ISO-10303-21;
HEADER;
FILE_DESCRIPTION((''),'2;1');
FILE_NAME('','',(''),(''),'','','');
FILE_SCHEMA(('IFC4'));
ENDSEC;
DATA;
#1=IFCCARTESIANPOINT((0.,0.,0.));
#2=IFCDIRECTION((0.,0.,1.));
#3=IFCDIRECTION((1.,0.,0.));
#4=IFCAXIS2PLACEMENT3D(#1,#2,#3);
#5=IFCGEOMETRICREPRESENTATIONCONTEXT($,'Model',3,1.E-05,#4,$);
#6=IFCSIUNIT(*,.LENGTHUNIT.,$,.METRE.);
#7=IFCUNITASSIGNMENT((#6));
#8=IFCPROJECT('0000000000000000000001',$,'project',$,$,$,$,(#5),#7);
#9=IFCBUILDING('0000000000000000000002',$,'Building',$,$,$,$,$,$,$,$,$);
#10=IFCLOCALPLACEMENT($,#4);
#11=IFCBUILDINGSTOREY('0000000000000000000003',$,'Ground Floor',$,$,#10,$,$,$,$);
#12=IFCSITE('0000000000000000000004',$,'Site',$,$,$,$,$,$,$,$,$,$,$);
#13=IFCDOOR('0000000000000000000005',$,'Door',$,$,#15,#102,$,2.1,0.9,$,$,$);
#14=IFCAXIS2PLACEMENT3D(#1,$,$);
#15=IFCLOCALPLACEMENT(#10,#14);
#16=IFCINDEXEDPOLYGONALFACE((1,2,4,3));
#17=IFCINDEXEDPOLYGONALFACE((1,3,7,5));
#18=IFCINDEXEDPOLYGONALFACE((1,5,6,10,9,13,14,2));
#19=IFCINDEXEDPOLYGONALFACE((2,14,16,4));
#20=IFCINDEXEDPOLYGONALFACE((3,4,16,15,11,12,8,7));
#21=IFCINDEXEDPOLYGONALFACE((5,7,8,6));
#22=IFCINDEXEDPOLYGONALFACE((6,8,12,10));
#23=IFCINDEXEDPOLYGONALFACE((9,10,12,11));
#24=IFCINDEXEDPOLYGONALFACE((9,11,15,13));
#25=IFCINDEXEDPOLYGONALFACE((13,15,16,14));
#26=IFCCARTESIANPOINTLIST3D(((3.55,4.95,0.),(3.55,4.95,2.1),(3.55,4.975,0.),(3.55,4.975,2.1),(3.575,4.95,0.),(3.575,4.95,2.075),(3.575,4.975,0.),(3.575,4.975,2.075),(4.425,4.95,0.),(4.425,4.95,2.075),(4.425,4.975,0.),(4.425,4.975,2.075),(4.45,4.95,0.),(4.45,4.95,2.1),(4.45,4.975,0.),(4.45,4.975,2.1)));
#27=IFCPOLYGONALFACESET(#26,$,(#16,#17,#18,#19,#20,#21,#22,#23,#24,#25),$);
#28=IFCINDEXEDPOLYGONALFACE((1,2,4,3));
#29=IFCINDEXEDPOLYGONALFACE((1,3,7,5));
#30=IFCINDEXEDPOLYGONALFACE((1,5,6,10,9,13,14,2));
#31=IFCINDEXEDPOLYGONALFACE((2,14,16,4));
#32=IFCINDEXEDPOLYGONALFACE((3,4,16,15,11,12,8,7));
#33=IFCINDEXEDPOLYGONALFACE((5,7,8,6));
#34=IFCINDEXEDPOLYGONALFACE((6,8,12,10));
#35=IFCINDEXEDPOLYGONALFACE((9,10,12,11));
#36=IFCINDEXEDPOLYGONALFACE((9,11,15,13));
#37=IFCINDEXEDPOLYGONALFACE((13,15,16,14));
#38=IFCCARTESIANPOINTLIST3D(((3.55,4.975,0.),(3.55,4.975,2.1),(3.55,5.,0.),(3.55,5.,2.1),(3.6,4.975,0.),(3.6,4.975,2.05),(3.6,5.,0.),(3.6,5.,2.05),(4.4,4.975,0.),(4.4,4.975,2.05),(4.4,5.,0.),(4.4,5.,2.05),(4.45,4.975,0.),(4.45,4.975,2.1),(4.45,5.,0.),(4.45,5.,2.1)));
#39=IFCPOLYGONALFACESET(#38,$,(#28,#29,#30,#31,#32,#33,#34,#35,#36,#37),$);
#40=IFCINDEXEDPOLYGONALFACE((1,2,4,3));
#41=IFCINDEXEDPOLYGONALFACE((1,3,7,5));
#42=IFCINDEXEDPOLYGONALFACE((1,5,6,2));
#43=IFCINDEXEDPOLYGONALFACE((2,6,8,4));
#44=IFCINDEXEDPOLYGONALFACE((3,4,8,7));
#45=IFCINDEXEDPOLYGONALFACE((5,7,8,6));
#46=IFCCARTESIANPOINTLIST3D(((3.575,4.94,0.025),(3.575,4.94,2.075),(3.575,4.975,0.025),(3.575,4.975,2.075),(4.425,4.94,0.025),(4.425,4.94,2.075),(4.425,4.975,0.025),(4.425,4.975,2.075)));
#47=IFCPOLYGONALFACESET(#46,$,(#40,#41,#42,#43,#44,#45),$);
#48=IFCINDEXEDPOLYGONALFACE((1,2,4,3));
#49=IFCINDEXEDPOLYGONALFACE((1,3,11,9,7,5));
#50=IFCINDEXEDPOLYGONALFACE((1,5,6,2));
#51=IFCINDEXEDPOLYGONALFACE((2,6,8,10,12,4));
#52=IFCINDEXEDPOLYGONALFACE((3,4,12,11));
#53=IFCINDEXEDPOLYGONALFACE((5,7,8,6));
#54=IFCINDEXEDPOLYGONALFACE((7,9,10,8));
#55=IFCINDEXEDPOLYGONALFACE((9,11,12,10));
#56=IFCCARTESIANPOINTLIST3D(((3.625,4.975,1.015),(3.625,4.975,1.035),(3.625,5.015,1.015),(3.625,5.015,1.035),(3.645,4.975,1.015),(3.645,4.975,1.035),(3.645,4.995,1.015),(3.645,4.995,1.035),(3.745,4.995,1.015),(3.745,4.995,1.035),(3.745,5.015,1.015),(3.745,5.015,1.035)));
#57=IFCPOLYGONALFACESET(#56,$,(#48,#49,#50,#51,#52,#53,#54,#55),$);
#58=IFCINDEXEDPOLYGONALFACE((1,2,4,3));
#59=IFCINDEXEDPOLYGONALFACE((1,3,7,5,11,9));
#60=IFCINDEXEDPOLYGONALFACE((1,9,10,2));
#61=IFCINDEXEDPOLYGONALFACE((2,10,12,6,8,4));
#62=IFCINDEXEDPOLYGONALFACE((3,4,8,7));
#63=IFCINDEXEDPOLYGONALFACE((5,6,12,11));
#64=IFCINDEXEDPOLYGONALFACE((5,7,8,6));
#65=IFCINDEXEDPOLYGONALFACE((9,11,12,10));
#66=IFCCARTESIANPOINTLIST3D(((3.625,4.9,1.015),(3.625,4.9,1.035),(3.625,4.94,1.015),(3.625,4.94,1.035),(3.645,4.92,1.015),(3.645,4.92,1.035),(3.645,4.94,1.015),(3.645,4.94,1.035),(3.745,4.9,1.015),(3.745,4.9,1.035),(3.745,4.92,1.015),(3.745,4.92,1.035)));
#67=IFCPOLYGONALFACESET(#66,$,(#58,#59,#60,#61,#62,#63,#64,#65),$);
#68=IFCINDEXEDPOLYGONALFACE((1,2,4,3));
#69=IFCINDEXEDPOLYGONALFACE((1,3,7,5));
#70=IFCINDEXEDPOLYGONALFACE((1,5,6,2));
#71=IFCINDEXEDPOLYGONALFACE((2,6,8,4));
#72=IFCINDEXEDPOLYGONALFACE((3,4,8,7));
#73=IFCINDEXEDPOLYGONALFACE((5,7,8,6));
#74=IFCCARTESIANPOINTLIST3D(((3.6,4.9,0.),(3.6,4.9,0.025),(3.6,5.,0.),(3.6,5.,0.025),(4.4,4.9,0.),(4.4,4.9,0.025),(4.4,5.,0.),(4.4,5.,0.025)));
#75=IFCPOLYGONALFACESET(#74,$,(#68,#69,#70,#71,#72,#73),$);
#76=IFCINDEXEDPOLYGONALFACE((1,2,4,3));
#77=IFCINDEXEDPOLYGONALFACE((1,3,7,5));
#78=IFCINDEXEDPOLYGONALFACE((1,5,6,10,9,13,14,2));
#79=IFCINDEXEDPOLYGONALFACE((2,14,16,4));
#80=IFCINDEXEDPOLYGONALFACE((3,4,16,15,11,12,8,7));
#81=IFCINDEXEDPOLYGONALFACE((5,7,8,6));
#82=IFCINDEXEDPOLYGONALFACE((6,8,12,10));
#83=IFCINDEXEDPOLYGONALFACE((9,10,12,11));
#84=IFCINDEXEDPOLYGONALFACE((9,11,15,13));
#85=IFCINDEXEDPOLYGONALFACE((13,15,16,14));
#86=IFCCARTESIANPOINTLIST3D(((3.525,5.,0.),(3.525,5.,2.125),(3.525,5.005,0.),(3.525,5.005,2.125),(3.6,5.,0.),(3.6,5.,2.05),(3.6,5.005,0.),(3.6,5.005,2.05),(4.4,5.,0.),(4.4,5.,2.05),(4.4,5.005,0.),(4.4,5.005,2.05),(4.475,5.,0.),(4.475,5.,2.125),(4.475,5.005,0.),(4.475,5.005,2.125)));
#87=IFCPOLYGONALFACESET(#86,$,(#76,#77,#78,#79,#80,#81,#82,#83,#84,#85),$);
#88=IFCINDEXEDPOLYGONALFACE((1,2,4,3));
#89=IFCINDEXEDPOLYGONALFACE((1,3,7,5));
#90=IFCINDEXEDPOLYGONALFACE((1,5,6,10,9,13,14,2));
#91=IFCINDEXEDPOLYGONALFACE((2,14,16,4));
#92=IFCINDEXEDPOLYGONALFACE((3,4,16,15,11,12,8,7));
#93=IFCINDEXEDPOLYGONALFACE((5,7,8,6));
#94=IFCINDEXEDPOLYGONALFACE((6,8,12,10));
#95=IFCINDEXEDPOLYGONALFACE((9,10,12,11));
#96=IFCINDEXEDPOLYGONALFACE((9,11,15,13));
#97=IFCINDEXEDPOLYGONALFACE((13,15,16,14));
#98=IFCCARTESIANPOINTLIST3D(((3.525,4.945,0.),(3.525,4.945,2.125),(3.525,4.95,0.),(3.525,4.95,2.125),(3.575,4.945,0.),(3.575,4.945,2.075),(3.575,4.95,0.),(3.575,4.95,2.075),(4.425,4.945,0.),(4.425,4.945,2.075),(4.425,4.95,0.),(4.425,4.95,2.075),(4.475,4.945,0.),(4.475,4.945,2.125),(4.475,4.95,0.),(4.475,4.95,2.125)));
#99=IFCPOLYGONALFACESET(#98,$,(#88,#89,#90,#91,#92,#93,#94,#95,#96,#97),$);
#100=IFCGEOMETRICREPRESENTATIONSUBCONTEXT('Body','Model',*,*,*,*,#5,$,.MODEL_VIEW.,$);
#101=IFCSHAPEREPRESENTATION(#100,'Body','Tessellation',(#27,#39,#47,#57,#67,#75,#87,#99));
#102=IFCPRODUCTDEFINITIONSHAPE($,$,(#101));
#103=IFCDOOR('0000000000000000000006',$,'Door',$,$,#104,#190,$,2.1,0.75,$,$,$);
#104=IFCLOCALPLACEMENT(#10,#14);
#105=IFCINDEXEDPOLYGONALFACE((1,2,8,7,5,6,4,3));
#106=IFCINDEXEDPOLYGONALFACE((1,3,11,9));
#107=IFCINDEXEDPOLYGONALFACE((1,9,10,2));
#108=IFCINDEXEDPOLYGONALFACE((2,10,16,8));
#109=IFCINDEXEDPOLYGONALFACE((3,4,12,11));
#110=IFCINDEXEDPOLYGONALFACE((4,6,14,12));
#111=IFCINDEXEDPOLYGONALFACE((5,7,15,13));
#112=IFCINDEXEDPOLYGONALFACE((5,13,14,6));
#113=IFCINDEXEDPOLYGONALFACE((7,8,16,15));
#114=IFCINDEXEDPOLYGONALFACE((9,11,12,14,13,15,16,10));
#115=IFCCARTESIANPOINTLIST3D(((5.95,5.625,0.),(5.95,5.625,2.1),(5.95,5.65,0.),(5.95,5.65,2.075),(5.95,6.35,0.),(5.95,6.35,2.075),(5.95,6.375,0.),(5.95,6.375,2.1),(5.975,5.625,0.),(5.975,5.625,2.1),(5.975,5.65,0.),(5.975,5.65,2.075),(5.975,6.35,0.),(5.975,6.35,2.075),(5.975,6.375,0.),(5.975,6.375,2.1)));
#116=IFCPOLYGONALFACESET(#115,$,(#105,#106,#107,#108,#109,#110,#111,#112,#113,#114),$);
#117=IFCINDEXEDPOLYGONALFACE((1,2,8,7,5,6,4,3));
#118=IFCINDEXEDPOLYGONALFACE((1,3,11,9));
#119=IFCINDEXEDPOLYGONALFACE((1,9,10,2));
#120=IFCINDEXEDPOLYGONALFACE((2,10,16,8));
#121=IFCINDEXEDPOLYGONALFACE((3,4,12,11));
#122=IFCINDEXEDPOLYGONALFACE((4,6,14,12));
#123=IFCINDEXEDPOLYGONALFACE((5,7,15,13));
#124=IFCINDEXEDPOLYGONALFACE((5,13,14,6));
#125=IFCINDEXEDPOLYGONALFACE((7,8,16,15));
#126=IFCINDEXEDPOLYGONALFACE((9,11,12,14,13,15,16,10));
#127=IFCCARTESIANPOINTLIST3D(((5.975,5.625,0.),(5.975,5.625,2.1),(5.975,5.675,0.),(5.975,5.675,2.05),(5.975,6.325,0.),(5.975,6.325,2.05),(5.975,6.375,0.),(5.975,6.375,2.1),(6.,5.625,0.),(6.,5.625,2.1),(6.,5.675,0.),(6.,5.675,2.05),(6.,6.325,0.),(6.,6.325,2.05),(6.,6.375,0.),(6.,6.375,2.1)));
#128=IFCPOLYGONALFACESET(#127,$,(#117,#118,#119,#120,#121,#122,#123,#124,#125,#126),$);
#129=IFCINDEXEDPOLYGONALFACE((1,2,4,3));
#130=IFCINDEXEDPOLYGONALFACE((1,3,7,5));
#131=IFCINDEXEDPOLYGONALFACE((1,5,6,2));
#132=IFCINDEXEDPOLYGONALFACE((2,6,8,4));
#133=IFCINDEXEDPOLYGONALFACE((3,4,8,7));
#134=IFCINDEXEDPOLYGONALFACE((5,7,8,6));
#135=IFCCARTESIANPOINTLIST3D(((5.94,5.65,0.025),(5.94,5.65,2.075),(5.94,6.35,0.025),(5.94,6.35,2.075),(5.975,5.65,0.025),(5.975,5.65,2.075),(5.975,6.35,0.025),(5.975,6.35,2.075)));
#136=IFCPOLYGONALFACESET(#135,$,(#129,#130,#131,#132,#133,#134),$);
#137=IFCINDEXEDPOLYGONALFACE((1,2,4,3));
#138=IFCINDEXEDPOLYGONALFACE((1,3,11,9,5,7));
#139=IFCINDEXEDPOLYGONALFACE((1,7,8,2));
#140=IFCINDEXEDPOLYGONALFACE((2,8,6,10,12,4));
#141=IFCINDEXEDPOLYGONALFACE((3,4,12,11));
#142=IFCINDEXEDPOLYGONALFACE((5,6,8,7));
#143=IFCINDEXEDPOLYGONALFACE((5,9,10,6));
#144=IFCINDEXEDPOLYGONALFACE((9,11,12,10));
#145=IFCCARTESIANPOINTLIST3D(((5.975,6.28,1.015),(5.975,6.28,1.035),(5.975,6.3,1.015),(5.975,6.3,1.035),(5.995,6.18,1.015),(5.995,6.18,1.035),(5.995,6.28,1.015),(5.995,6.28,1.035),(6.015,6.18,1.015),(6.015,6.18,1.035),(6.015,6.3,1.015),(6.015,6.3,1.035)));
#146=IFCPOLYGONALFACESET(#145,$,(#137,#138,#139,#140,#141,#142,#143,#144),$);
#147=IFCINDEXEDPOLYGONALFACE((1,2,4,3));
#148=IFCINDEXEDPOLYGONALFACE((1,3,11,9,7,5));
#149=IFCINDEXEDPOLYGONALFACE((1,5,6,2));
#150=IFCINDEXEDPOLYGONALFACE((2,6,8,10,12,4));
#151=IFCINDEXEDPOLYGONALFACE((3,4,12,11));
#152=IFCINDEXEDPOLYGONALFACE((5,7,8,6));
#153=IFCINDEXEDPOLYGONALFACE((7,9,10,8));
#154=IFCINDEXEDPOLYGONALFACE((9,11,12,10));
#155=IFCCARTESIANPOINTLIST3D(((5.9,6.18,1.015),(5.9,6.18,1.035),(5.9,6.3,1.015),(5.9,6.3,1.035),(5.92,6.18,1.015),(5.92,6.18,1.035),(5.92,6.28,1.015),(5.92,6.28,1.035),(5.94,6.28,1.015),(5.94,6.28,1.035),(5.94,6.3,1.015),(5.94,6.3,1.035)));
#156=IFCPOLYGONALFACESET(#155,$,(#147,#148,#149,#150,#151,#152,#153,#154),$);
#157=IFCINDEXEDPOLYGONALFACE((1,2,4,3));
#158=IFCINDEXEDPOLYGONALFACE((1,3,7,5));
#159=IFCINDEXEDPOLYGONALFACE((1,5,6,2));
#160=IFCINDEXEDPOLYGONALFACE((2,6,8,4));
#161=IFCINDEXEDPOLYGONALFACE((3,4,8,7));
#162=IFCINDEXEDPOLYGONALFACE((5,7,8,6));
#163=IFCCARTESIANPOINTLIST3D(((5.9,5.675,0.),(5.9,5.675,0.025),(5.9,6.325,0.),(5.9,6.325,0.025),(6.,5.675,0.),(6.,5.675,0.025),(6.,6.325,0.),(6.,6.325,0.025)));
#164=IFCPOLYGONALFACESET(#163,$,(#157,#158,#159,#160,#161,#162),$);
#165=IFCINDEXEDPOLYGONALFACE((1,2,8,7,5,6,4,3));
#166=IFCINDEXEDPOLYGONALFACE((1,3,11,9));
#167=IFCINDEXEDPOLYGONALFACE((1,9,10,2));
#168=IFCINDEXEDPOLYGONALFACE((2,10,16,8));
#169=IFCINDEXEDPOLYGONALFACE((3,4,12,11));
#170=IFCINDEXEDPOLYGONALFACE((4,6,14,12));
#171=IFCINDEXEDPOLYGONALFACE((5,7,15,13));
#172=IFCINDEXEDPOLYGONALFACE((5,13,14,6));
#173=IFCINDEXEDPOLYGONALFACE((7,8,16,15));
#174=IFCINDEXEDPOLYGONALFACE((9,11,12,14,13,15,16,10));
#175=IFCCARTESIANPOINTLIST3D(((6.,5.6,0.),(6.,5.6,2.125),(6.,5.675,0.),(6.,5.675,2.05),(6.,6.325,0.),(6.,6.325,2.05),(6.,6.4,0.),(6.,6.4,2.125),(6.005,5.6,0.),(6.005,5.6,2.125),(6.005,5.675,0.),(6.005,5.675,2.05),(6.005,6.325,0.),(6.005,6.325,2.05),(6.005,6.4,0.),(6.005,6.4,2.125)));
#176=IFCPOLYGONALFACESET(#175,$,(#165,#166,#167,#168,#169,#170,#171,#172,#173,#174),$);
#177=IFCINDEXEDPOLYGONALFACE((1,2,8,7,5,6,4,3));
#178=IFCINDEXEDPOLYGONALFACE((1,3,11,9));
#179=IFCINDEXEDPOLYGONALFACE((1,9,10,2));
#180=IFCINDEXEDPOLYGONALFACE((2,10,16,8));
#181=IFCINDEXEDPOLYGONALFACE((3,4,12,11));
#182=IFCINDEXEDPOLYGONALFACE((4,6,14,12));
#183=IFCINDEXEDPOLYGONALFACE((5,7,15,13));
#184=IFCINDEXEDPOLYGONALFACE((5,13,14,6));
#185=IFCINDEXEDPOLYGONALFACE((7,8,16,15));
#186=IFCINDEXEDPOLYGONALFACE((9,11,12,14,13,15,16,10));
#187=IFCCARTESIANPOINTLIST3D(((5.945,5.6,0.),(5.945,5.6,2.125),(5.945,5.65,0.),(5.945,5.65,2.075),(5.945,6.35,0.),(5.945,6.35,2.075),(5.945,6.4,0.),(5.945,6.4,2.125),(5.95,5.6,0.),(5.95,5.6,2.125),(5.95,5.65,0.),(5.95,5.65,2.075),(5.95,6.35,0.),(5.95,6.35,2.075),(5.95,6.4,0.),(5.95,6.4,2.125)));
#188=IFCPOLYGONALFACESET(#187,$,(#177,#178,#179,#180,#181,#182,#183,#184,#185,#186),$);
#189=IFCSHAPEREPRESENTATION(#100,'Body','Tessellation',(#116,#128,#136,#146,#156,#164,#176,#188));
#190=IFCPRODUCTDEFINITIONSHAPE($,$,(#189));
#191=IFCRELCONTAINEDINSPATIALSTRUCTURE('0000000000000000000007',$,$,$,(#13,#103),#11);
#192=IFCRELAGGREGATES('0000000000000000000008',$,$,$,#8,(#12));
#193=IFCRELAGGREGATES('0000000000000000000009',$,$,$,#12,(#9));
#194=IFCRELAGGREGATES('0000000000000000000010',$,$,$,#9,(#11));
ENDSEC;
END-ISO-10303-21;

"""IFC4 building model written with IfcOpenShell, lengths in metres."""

from ifc_helpers import new_model, si_unit, frame, origin_with_axes, place, context, subcontext, project, spatial, line, indexed_curve, outline, extrude, element, save


model = new_model("IFC4")

# Units and contexts
model_context = context("Model", 3, precision=1e-05, world=origin_with_axes())
body_context = subcontext(model_context, "Body", "Model", "MODEL_VIEW")
ifc_project = project(units=[si_unit("LENGTHUNIT", "METRE")], contexts=[model_context])

# Site, building, storey
site = spatial("IfcSite", under=ifc_project, Name="Site")
building = spatial("IfcBuilding", under=site, Name="Building")
storey_placement = place(None, origin_with_axes())
storey = spatial("IfcBuildingStorey", under=building, at=storey_placement, Name="Ground Floor")

# Doors
door_1_placement = place(storey_placement, frame((4.45, 5.0, 0.0), z_axis=(0.0, 0.0, 1.0), x_axis=(-1.0, 0.0, 0.0)))
element("IfcDoor", 1, at=door_1_placement, inside=storey, Name="Door", OverallHeight=2.1, OverallWidth=0.9, context=body_context, shape_type="SweptSolid", body=[
    extrude(outline(indexed_curve([(0.0, 0.0), (0.0, 2.1), (0.9, 2.1), (0.9, 0.0), (0.875, 0.0), (0.875, 2.075), (0.025, 2.075), (0.025, 0.0)], segments=[line(1, 2, 3, 4, 5, 6, 7, 8, 1)])), frame((0.0, 0.025, 0.0), z_axis=(0.0, -1.0, 0.0), x_axis=(1.0, 0.0, 0.0)), (0.0, 0.0, -1.0), 0.025),
    extrude(outline(indexed_curve([(0.0, 0.0), (0.0, 2.1), (0.9, 2.1), (0.9, 0.0), (0.85, 0.0), (0.85, 2.05), (0.05, 2.05), (0.05, 0.0)], segments=[line(1, 2, 3, 4, 5, 6, 7, 8, 1)])), frame((0.0, 0.0, 0.0), z_axis=(0.0, -1.0, 0.0), x_axis=(1.0, 0.0, 0.0)), (0.0, 0.0, -1.0), 0.025),
    extrude(outline(indexed_curve([(0.0, 0.0), (0.85, 0.0), (0.85, 0.035), (0.0, 0.035)], segments=[line(1, 2, 3, 4, 1)])), frame((0.025, 0.025, 0.025), z_axis=(0.0, 0.0, 1.0), x_axis=(1.0, 0.0, 0.0)), (0.0, 0.0, 1.0), 2.05),
    extrude(outline(indexed_curve([(0.0, 0.0), (0.0, -0.04), (-0.12, -0.04), (-0.12, -0.02), (-0.02, -0.02), (-0.02, 0.0)], segments=[line(1, 2, 3, 4, 5, 6, 1)])), frame((0.825, 0.025, 1.015), z_axis=(0.0, 0.0, 1.0), x_axis=(1.0, 0.0, 0.0)), (0.0, 0.0, 1.0), 0.02),
    extrude(outline(indexed_curve([(0.0, 0.0), (0.0, 0.04), (-0.12, 0.04), (-0.12, 0.02), (-0.02, 0.02), (-0.02, 0.0)], segments=[line(1, 2, 3, 4, 5, 6, 1)])), frame((0.825, 0.06, 1.015), z_axis=(0.0, 0.0, 1.0), x_axis=(1.0, 0.0, 0.0)), (0.0, 0.0, 1.0), 0.02),
    extrude(outline(indexed_curve([(0.0, 0.0), (0.8, 0.0), (0.8, 0.1), (0.0, 0.1)], segments=[line(1, 2, 3, 4, 1)])), frame((0.05, 0.0, 0.0), z_axis=(0.0, 0.0, 1.0), x_axis=(1.0, 0.0, 0.0)), (0.0, 0.0, 1.0), 0.025),
    extrude(outline(indexed_curve([(0.0, 0.0), (0.0, 2.125), (0.95, 2.125), (0.95, 0.0), (0.875, 0.0), (0.875, 2.05), (0.075, 2.05), (0.075, 0.0)], segments=[line(1, 2, 3, 4, 5, 6, 7, 8, 1)])), frame((-0.025, -0.005, 0.0), z_axis=(0.0, -1.0, 0.0), x_axis=(1.0, 0.0, 0.0)), (0.0, 0.0, -1.0), 0.005),
    extrude(outline(indexed_curve([(0.0, 0.0), (0.0, 2.125), (0.95, 2.125), (0.95, 0.0), (0.9, 0.0), (0.9, 2.075), (0.05, 2.075), (0.05, 0.0)], segments=[line(1, 2, 3, 4, 5, 6, 7, 8, 1)])), frame((-0.025, 0.05, 0.0), z_axis=(0.0, -1.0, 0.0), x_axis=(1.0, 0.0, 0.0)), (0.0, 0.0, -1.0), 0.005),
])
door_2_placement = place(storey_placement, frame((6.0, 5.625, 0.0), z_axis=(0.0, 0.0, 1.0), x_axis=(0.0, 1.0, 0.0)))
element("IfcDoor", 2, at=door_2_placement, inside=storey, Name="Door", OverallHeight=2.1, OverallWidth=0.75, context=body_context, shape_type="SweptSolid", body=[
    extrude(outline(indexed_curve([(0.0, 0.0), (0.0, 2.1), (0.75, 2.1), (0.75, 0.0), (0.725, 0.0), (0.725, 2.075), (0.025, 2.075), (0.025, 0.0)], segments=[line(1, 2, 3, 4, 5, 6, 7, 8, 1)])), frame((0.0, 0.025, 0.0), z_axis=(0.0, -1.0, 0.0), x_axis=(1.0, 0.0, 0.0)), (0.0, 0.0, -1.0), 0.025),
    extrude(outline(indexed_curve([(0.0, 0.0), (0.0, 2.1), (0.75, 2.1), (0.75, 0.0), (0.7, 0.0), (0.7, 2.05), (0.05, 2.05), (0.05, 0.0)], segments=[line(1, 2, 3, 4, 5, 6, 7, 8, 1)])), frame((0.0, 0.0, 0.0), z_axis=(0.0, -1.0, 0.0), x_axis=(1.0, 0.0, 0.0)), (0.0, 0.0, -1.0), 0.025),
    extrude(outline(indexed_curve([(0.0, 0.0), (0.7, 0.0), (0.7, 0.035), (0.0, 0.035)], segments=[line(1, 2, 3, 4, 1)])), frame((0.025, 0.025, 0.025), z_axis=(0.0, 0.0, 1.0), x_axis=(1.0, 0.0, 0.0)), (0.0, 0.0, 1.0), 2.05),
    extrude(outline(indexed_curve([(0.0, 0.0), (0.0, -0.04), (-0.12, -0.04), (-0.12, -0.02), (-0.02, -0.02), (-0.02, 0.0)], segments=[line(1, 2, 3, 4, 5, 6, 1)])), frame((0.675, 0.025, 1.015), z_axis=(0.0, 0.0, 1.0), x_axis=(1.0, 0.0, 0.0)), (0.0, 0.0, 1.0), 0.02),
    extrude(outline(indexed_curve([(0.0, 0.0), (0.0, 0.04), (-0.12, 0.04), (-0.12, 0.02), (-0.02, 0.02), (-0.02, 0.0)], segments=[line(1, 2, 3, 4, 5, 6, 1)])), frame((0.675, 0.06, 1.015), z_axis=(0.0, 0.0, 1.0), x_axis=(1.0, 0.0, 0.0)), (0.0, 0.0, 1.0), 0.02),
    extrude(outline(indexed_curve([(0.0, 0.0), (0.65, 0.0), (0.65, 0.1), (0.0, 0.1)], segments=[line(1, 2, 3, 4, 1)])), frame((0.05, 0.0, 0.0), z_axis=(0.0, 0.0, 1.0), x_axis=(1.0, 0.0, 0.0)), (0.0, 0.0, 1.0), 0.025),
    extrude(outline(indexed_curve([(0.0, 0.0), (0.0, 2.125), (0.8, 2.125), (0.8, 0.0), (0.725, 0.0), (0.725, 2.05), (0.075, 2.05), (0.075, 0.0)], segments=[line(1, 2, 3, 4, 5, 6, 7, 8, 1)])), frame((-0.025, -0.005, 0.0), z_axis=(0.0, -1.0, 0.0), x_axis=(1.0, 0.0, 0.0)), (0.0, 0.0, -1.0), 0.005),
    extrude(outline(indexed_curve([(0.0, 0.0), (0.0, 2.125), (0.8, 2.125), (0.8, 0.0), (0.75, 0.0), (0.75, 2.075), (0.05, 2.075), (0.05, 0.0)], segments=[line(1, 2, 3, 4, 5, 6, 7, 8, 1)])), frame((-0.025, 0.05, 0.0), z_axis=(0.0, -1.0, 0.0), x_axis=(1.0, 0.0, 0.0)), (0.0, 0.0, -1.0), 0.005),
])

save(model, "model.ifc")
